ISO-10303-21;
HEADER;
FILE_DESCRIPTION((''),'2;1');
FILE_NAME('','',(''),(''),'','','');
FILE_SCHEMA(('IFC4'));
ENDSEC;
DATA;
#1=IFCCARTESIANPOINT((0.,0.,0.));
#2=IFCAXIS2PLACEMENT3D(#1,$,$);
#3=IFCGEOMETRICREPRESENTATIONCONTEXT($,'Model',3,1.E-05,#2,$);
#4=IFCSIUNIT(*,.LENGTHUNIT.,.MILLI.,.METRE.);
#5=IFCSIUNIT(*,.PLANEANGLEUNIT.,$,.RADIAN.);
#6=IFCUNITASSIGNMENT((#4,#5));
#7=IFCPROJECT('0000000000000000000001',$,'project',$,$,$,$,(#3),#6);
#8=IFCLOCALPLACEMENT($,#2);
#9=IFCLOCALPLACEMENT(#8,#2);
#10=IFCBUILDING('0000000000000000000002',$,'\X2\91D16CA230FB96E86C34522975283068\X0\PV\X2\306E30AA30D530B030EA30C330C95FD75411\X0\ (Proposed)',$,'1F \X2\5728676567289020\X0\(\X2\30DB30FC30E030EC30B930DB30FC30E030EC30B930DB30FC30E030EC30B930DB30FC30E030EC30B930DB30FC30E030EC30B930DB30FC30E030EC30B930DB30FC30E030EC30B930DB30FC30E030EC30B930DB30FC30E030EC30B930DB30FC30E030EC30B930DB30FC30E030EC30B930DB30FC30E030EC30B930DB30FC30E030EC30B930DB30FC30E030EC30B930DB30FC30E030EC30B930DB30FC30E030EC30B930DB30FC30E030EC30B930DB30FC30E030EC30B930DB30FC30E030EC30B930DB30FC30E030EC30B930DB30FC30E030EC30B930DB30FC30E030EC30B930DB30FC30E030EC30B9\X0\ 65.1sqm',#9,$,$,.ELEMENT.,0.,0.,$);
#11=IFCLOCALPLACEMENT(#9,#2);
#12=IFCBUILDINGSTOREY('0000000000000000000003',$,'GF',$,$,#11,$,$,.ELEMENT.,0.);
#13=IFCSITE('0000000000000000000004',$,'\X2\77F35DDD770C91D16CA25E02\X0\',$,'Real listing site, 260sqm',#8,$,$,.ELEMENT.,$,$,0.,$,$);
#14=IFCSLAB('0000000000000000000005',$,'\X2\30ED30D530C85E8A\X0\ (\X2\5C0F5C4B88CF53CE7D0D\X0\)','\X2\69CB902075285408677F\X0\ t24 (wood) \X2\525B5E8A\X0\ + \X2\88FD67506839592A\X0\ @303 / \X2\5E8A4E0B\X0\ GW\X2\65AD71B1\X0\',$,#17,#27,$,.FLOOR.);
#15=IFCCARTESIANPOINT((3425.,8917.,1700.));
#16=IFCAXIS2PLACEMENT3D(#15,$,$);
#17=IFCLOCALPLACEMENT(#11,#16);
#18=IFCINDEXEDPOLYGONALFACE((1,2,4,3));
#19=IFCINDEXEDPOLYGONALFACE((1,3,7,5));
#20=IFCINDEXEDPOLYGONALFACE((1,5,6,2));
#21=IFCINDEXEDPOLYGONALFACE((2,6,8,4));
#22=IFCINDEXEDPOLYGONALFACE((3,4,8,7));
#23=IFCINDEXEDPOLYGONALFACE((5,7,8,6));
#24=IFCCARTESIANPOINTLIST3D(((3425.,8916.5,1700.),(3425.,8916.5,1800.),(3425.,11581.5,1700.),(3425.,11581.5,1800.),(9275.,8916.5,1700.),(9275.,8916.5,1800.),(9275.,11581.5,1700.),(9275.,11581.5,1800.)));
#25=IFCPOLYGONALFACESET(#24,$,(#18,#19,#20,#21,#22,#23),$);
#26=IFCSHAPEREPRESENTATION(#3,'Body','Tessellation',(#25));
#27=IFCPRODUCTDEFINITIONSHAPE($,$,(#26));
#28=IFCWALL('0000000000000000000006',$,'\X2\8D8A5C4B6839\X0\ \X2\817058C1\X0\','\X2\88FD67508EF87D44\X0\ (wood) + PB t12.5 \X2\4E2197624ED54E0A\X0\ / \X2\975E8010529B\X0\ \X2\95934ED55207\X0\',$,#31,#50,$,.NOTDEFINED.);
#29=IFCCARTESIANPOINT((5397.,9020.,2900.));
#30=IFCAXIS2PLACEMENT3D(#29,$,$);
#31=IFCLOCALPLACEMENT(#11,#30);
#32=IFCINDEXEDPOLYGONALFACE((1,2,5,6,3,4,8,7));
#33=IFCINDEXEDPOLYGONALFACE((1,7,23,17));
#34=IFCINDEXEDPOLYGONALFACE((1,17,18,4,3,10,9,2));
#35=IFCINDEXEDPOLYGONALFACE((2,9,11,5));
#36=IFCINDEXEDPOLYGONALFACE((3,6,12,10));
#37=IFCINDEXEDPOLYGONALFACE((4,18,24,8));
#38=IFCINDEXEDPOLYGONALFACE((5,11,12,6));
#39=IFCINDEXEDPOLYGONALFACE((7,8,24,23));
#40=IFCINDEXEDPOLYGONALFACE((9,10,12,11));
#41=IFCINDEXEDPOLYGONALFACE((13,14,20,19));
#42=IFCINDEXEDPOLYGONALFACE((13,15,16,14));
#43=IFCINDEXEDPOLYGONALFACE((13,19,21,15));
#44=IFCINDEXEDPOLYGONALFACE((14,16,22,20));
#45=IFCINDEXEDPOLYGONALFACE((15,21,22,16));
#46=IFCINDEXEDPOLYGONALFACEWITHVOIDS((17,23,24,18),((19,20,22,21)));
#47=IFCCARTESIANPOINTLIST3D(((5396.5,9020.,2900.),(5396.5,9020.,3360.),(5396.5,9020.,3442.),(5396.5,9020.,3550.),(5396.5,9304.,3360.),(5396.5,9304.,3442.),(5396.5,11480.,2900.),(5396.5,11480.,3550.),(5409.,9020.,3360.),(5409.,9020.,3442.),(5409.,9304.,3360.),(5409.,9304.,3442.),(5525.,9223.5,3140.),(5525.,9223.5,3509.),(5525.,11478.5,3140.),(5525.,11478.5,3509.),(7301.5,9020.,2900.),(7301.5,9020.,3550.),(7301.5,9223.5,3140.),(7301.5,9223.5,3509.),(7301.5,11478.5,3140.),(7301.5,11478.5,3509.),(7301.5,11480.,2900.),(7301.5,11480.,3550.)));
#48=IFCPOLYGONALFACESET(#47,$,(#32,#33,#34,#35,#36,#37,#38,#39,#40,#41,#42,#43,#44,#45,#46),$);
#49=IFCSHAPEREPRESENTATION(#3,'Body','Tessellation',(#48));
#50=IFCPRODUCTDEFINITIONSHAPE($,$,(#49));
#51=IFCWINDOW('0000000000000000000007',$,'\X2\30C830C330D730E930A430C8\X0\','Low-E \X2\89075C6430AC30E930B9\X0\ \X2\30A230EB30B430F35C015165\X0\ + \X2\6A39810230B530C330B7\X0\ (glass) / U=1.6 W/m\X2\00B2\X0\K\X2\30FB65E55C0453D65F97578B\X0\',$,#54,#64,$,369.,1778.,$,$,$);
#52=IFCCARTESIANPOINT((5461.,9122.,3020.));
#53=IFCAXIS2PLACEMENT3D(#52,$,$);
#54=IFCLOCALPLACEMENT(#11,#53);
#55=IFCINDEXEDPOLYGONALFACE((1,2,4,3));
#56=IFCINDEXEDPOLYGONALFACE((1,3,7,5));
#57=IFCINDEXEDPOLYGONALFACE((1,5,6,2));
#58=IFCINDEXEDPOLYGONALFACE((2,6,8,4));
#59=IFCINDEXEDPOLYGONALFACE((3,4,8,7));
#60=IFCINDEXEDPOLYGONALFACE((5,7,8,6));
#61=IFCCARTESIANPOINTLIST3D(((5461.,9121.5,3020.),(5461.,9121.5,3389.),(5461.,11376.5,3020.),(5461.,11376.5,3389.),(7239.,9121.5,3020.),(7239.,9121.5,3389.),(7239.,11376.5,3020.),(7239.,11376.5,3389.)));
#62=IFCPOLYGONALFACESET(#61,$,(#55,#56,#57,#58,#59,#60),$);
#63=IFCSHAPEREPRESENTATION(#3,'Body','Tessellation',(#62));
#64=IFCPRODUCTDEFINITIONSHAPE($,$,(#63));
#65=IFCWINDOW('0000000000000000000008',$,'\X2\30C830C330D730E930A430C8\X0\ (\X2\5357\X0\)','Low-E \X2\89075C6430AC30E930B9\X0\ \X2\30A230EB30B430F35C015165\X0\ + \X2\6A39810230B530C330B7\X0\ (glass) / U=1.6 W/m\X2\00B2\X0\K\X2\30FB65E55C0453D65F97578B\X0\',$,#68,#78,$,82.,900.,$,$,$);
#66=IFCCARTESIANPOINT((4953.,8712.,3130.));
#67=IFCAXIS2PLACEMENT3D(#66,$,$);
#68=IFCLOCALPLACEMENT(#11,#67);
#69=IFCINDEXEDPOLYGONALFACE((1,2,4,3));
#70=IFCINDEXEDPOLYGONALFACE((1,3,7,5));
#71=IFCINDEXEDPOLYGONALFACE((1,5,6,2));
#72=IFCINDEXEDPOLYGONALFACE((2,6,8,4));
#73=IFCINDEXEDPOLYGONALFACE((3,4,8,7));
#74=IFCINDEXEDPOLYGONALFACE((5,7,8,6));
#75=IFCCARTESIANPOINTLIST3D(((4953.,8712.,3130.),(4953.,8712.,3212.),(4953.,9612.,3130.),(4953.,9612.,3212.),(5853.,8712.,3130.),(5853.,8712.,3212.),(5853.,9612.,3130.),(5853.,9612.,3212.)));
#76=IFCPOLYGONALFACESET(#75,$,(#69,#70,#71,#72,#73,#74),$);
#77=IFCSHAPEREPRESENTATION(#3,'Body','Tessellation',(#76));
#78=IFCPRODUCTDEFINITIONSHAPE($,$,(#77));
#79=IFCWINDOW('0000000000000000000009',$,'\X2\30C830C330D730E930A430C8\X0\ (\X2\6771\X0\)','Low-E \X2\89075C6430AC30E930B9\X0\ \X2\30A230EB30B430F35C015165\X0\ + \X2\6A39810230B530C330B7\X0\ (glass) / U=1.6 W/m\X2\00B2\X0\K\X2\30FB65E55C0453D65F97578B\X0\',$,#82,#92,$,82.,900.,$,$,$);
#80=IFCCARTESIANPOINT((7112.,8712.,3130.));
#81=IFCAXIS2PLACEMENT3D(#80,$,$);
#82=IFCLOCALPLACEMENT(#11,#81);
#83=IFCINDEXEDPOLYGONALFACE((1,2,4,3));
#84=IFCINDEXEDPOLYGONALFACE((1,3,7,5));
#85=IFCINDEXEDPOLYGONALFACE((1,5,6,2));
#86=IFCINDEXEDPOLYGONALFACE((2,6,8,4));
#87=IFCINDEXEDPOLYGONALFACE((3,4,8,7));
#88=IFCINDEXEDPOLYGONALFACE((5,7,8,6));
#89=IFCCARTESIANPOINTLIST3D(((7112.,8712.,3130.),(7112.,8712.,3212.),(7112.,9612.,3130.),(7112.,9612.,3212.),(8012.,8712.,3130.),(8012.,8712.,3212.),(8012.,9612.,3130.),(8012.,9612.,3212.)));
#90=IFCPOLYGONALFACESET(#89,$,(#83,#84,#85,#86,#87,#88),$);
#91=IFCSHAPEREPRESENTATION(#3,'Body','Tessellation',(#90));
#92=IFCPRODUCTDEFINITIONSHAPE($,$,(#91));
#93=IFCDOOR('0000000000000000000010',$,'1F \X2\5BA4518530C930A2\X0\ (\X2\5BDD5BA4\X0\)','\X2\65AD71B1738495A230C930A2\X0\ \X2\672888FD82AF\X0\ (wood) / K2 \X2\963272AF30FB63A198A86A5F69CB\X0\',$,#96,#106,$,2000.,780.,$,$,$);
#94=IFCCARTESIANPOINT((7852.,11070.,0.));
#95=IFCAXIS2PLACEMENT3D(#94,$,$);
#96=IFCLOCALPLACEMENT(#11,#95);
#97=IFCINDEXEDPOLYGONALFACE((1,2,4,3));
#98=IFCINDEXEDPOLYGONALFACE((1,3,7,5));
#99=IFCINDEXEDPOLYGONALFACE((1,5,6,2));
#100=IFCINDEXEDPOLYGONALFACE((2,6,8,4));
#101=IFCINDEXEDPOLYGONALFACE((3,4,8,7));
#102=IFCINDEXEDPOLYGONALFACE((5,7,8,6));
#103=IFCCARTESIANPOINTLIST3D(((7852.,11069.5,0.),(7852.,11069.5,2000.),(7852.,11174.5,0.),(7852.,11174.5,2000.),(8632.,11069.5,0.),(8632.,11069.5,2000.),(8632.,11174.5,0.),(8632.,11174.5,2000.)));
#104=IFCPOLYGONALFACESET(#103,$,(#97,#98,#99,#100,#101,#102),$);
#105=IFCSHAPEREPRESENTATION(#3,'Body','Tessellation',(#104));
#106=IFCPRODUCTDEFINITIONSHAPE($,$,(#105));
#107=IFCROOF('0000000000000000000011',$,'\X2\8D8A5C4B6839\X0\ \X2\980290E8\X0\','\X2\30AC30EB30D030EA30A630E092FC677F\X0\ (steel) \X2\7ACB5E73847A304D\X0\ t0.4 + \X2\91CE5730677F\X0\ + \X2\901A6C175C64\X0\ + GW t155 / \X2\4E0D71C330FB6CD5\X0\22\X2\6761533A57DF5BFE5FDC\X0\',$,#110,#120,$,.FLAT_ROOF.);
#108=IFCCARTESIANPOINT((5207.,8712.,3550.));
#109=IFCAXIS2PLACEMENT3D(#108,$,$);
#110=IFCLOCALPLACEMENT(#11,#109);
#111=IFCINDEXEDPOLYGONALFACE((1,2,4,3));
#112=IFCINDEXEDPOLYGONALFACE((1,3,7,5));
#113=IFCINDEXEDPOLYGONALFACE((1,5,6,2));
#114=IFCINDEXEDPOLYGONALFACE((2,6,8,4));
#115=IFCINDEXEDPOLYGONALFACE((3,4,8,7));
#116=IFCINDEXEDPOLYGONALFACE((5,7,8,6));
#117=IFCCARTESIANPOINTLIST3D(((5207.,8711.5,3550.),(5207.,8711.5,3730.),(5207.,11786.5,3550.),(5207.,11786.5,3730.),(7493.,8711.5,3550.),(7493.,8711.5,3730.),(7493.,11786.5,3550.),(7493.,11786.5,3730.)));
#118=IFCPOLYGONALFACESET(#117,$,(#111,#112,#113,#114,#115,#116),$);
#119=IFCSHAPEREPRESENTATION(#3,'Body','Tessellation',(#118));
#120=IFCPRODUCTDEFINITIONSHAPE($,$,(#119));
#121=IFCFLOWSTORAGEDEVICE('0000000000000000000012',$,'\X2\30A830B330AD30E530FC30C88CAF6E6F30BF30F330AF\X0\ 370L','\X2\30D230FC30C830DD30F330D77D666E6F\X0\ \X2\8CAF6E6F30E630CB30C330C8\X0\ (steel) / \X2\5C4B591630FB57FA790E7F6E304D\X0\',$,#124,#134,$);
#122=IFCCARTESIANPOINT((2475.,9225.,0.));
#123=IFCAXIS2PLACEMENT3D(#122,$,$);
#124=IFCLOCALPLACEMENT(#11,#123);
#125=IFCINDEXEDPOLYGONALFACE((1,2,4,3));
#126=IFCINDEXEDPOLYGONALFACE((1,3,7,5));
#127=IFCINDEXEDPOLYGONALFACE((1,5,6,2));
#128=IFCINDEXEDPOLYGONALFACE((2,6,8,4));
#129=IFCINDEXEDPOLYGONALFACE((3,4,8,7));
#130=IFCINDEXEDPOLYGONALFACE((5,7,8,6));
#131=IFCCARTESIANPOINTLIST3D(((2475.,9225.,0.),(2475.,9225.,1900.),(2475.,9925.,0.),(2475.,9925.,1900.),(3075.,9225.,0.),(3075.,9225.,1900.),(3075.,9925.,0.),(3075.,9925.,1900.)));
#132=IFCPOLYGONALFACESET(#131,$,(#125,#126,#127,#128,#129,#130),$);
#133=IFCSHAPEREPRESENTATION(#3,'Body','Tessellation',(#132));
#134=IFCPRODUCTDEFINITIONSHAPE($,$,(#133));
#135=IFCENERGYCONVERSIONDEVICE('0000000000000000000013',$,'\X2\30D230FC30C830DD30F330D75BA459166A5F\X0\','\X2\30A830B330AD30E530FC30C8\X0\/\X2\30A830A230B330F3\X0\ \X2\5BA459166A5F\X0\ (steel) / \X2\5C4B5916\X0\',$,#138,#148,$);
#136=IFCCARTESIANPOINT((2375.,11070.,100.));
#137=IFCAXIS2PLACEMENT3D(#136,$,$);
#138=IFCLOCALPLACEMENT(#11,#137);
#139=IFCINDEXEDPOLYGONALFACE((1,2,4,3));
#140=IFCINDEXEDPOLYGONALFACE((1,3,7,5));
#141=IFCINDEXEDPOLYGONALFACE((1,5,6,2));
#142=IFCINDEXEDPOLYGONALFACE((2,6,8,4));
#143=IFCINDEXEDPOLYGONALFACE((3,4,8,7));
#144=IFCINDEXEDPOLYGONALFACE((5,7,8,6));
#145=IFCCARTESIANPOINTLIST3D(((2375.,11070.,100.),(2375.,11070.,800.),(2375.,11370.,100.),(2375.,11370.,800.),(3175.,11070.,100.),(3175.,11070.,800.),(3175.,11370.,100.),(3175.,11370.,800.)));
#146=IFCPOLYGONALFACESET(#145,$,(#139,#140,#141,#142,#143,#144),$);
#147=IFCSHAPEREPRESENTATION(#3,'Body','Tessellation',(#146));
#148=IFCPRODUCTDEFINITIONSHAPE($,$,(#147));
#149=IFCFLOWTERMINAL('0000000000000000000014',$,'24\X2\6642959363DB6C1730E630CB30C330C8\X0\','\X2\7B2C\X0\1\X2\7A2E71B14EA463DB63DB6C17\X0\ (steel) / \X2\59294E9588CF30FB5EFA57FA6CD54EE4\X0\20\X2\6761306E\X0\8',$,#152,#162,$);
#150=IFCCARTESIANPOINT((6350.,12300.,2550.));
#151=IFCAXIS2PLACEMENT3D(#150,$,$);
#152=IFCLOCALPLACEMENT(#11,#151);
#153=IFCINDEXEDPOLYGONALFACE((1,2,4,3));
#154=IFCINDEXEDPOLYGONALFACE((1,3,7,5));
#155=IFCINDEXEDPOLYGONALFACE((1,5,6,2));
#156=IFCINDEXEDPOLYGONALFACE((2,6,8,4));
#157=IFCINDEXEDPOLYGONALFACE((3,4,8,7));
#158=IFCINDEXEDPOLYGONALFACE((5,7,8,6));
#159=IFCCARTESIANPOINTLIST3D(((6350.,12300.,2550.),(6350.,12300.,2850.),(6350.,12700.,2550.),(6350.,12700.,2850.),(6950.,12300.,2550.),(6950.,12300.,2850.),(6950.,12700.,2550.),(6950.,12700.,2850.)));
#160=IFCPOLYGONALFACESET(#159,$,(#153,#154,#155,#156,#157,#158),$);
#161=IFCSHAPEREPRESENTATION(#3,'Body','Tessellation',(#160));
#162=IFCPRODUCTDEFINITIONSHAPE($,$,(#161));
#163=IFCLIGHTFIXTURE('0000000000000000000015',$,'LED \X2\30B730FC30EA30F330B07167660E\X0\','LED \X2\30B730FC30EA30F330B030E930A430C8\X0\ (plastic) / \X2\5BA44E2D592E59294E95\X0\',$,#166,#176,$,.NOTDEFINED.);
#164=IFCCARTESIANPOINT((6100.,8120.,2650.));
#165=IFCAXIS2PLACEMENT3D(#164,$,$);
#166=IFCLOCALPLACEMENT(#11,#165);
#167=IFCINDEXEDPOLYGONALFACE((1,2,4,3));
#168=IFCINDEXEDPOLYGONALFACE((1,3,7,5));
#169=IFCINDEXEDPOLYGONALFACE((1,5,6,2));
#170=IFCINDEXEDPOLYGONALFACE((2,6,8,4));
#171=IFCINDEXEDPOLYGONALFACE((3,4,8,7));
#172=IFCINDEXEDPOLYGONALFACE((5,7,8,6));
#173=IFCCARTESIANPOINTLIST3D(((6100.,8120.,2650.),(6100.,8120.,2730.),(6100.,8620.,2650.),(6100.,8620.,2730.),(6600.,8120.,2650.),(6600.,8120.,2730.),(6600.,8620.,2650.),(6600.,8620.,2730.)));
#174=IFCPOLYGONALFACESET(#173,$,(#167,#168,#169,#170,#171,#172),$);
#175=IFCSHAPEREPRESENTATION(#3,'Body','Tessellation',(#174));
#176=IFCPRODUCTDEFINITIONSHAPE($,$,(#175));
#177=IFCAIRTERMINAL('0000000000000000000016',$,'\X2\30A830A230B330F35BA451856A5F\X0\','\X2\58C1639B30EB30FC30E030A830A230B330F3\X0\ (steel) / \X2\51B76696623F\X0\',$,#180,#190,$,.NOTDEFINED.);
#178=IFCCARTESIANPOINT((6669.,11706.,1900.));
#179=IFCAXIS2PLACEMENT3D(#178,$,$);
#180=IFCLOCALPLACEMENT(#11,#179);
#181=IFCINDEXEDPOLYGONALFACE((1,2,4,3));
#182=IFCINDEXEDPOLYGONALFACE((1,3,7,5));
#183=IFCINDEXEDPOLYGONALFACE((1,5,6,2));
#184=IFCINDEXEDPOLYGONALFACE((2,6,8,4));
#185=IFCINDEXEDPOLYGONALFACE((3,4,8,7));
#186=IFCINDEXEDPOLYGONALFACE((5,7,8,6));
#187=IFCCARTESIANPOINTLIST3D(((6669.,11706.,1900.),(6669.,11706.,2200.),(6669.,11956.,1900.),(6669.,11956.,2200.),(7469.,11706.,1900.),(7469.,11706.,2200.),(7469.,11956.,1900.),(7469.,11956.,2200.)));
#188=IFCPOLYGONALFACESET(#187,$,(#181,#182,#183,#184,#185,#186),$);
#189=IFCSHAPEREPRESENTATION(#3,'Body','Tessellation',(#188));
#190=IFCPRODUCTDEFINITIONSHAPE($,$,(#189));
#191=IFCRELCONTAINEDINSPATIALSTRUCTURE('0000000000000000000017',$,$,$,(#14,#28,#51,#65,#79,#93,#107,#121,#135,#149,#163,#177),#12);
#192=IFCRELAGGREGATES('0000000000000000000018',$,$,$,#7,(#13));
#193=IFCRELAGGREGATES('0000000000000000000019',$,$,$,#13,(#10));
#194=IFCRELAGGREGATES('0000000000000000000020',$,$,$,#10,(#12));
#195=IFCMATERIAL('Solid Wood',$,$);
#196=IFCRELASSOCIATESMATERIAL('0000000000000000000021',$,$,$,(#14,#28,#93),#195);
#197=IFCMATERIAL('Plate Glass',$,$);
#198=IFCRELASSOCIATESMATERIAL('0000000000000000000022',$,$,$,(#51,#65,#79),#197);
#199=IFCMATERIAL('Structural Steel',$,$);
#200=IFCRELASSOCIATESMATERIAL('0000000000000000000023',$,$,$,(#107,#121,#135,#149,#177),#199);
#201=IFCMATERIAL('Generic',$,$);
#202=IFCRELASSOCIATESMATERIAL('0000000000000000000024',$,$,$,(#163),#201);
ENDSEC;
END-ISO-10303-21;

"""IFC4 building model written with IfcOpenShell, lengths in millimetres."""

from ifc_helpers import new_model, si_unit, frame, frame_2d, origin, place, context, project, spatial, rectangle, extrude, material, element, fill, save


model = new_model("IFC4")

# Units and contexts
model_context = context("Model", 3, precision=1e-05, world=origin())
ifc_project = project(units=[si_unit("LENGTHUNIT", "METRE", prefix="MILLI"), si_unit("PLANEANGLEUNIT", "RADIAN")], contexts=[model_context])

# Site, building, storey
site_placement = place(None, origin())
site = spatial("IfcSite", under=ifc_project, at=site_placement, Name="石川県金沢市", ObjectType="Real listing site, 260sqm", CompositionType="ELEMENT", RefElevation=0.0)
building_placement = place(site_placement, origin())
building = spatial("IfcBuilding", under=site, at=building_placement, Name="金沢・雨水利用とPVのオフグリッド志向 (Proposed)", ObjectType="1F 在来木造(ホームレスホームレスホームレスホームレスホームレスホームレスホームレスホームレスホームレスホームレスホームレスホームレスホームレスホームレスホームレスホームレスホームレスホームレスホームレスホームレスホームレスホームレスホームレス 65.1sqm", CompositionType="ELEMENT", ElevationOfRefHeight=0.0, ElevationOfTerrain=0.0)
storey_placement = place(building_placement, origin())
storey = spatial("IfcBuildingStorey", under=building, at=storey_placement, Name="GF", CompositionType="ELEMENT", Elevation=0.0)

# Shared definitions
ifc_material_1 = material(Name="Solid Wood")

# Slab
slab_placement = place(storey_placement, frame((3425.0, 8917.0, 1700.0)))
element("IfcSlab", 1, at=slab_placement, inside=storey, material=ifc_material_1, Name="ロフト床 (小屋裏収納)", Description="構造用合板 t24 (wood) 剛床 + 製材根太 @303 / 床下 GW断熱", PredefinedType="FLOOR", context=model_context, shape_type="SweptSolid", body=[
    extrude(rectangle(XDim=5850.0, YDim=2665.0, at=frame_2d((2925.0, 1332.0))), frame((3425.0, 8917.0, 1700.0)), (0.0, 0.0, 1.0), 100.0),
])

# Wall, openings, windows
wall_1_placement = place(storey_placement, frame((5397.0, 9020.0, 2900.0)))
wall_1 = element("IfcWall", 2, at=wall_1_placement, inside=storey, material=ifc_material_1, Name="越屋根 腰壁", Description="製材軸組 (wood) + PB t12.5 両面仕上 / 非耐力 間仕切", PredefinedType="NOTDEFINED", context=model_context, shape_type="SweptSolid", body=[
    extrude(rectangle(XDim=1905.0, YDim=2460.0, at=frame_2d((952.0, 1230.0))), frame((5397.0, 9020.0, 2900.0)), (0.0, 0.0, 1.0), 650.0),
])
opening_1_placement = place(storey_placement, frame((5461.0, 9122.0, 3020.0)))
opening_1 = element("IfcOpeningElement", 3, at=opening_1_placement, cuts=wall_1, PredefinedType="NOTDEFINED", context=model_context, shape_type="SweptSolid", body=[
    extrude(rectangle(XDim=1778.0, YDim=2255.0, at=frame_2d((889.0, 1127.0))), frame((5461.0, 9122.0, 3020.0)), (0.0, 0.0, 1.0), 369.0),
])
opening_2_placement = place(storey_placement, frame((4953.0, 8712.0, 3130.0)))
opening_2 = element("IfcOpeningElement", 4, at=opening_2_placement, cuts=wall_1, PredefinedType="NOTDEFINED", context=model_context, shape_type="SweptSolid", body=[
    extrude(rectangle(XDim=900.0, YDim=900.0, at=frame_2d((450.0, 450.0))), frame((4953.0, 8712.0, 3130.0)), (0.0, 0.0, 1.0), 82.0),
])
opening_3_placement = place(storey_placement, frame((7112.0, 8712.0, 3130.0)))
opening_3 = element("IfcOpeningElement", 5, at=opening_3_placement, cuts=wall_1, PredefinedType="NOTDEFINED", context=model_context, shape_type="SweptSolid", body=[
    extrude(rectangle(XDim=900.0, YDim=900.0, at=frame_2d((450.0, 450.0))), frame((7112.0, 8712.0, 3130.0)), (0.0, 0.0, 1.0), 82.0),
])
ifc_material_2 = material(Name="Plate Glass")
window_1_placement = place(storey_placement, frame((5461.0, 9122.0, 3020.0)))
window_1 = element("IfcWindow", 6, at=window_1_placement, inside=storey, material=ifc_material_2, Name="トップライト", Description="Low-E 複層ガラス アルゴン封入 + 樹脂サッシ (glass) / U=1.6 W/m²K・日射取得型", OverallHeight=369.0, OverallWidth=1778.0, context=model_context, shape_type="SweptSolid", body=[
    extrude(rectangle(XDim=1778.0, YDim=2255.0, at=frame_2d((889.0, 1127.0))), frame((5461.0, 9122.0, 3020.0)), (0.0, 0.0, 1.0), 369.0),
])
fill(opening_1, window_1)
window_2_placement = place(storey_placement, frame((4953.0, 8712.0, 3130.0)))
window_2 = element("IfcWindow", 7, at=window_2_placement, inside=storey, material=ifc_material_2, Name="トップライト (南)", Description="Low-E 複層ガラス アルゴン封入 + 樹脂サッシ (glass) / U=1.6 W/m²K・日射取得型", OverallHeight=82.0, OverallWidth=900.0, context=model_context, shape_type="SweptSolid", body=[
    extrude(rectangle(XDim=900.0, YDim=900.0, at=frame_2d((450.0, 450.0))), frame((4953.0, 8712.0, 3130.0)), (0.0, 0.0, 1.0), 82.0),
])
fill(opening_2, window_2)
window_3_placement = place(storey_placement, frame((7112.0, 8712.0, 3130.0)))
window_3 = element("IfcWindow", 8, at=window_3_placement, inside=storey, material=ifc_material_2, Name="トップライト (東)", Description="Low-E 複層ガラス アルゴン封入 + 樹脂サッシ (glass) / U=1.6 W/m²K・日射取得型", OverallHeight=82.0, OverallWidth=900.0, context=model_context, shape_type="SweptSolid", body=[
    extrude(rectangle(XDim=900.0, YDim=900.0, at=frame_2d((450.0, 450.0))), frame((7112.0, 8712.0, 3130.0)), (0.0, 0.0, 1.0), 82.0),
])
fill(opening_3, window_3)

# Door
door_1_placement = place(storey_placement, frame((7852.0, 11070.0, 0.0)))
element("IfcDoor", 9, at=door_1_placement, inside=storey, material=ifc_material_1, Name="1F 室内ドア (寝室)", Description="断熱玄関ドア 木製芯 (wood) / K2 防犯・採風機構", OverallHeight=2000.0, OverallWidth=780.0, context=model_context, shape_type="SweptSolid", body=[
    extrude(rectangle(XDim=780.0, YDim=105.0, at=frame_2d((390.0, 52.0))), frame((7852.0, 11070.0, 0.0)), (0.0, 0.0, 1.0), 2000.0),
])

# Roof
ifc_material_3 = material(Name="Structural Steel")
roof_placement = place(storey_placement, frame((5207.0, 8712.0, 3550.0)))
element("IfcRoof", 10, at=roof_placement, inside=storey, material=ifc_material_3, Name="越屋根 頂部", Description="ガルバリウム鋼板 (steel) 立平葺き t0.4 + 野地板 + 通気層 + GW t155 / 不燃・法22条区域対応", PredefinedType="FLAT_ROOF", context=model_context, shape_type="SweptSolid", body=[
    extrude(rectangle(XDim=2286.0, YDim=3075.0, at=frame_2d((1143.0, 1537.0))), frame((5207.0, 8712.0, 3550.0)), (0.0, 0.0, 1.0), 180.0),
])

# Flow storage device
flow_storage_device_placement = place(storey_placement, frame((2475.0, 9225.0, 0.0)))
element("IfcFlowStorageDevice", 11, at=flow_storage_device_placement, inside=storey, material=ifc_material_3, Name="エコキュート貯湯タンク 370L", Description="ヒートポンプ給湯 貯湯ユニット (steel) / 屋外・基礎置き", context=model_context, shape_type="SweptSolid", body=[
    extrude(rectangle(XDim=600.0, YDim=700.0, at=frame_2d((300.0, 350.0))), frame((2475.0, 9225.0, 0.0)), (0.0, 0.0, 1.0), 1900.0),
])

# Energy conversion device
energy_conversion_device_placement = place(storey_placement, frame((2375.0, 11070.0, 100.0)))
element("IfcEnergyConversionDevice", 12, at=energy_conversion_device_placement, inside=storey, material=ifc_material_3, Name="ヒートポンプ室外機", Description="エコキュート/エアコン 室外機 (steel) / 屋外", context=model_context, shape_type="SweptSolid", body=[
    extrude(rectangle(XDim=800.0, YDim=300.0, at=frame_2d((400.0, 150.0))), frame((2375.0, 11070.0, 100.0)), (0.0, 0.0, 1.0), 700.0),
])

# Flow terminal
flow_terminal_placement = place(storey_placement, frame((6350.0, 12300.0, 2550.0)))
element("IfcFlowTerminal", 13, at=flow_terminal_placement, inside=storey, material=ifc_material_3, Name="24時間換気ユニット", Description="第1種熱交換換気 (steel) / 天井裏・建基法令20条の8", context=model_context, shape_type="SweptSolid", body=[
    extrude(rectangle(XDim=600.0, YDim=400.0, at=frame_2d((300.0, 200.0))), frame((6350.0, 12300.0, 2550.0)), (0.0, 0.0, 1.0), 300.0),
])

# Light fixture
ifc_material_4 = material(Name="Generic")
light_fixture_placement = place(storey_placement, frame((6100.0, 8120.0, 2650.0)))
element("IfcLightFixture", 14, at=light_fixture_placement, inside=storey, material=ifc_material_4, Name="LED シーリング照明", Description="LED シーリングライト (plastic) / 室中央天井", PredefinedType="NOTDEFINED", context=model_context, shape_type="SweptSolid", body=[
    extrude(rectangle(XDim=500.0, YDim=500.0, at=frame_2d((250.0, 250.0))), frame((6100.0, 8120.0, 2650.0)), (0.0, 0.0, 1.0), 80.0),
])

# Air terminal
air_terminal_placement = place(storey_placement, frame((6669.0, 11706.0, 1900.0)))
element("IfcAirTerminal", 15, at=air_terminal_placement, inside=storey, material=ifc_material_3, Name="エアコン室内機", Description="壁掛ルームエアコン (steel) / 冷暖房", PredefinedType="NOTDEFINED", context=model_context, shape_type="SweptSolid", body=[
    extrude(rectangle(XDim=800.0, YDim=250.0, at=frame_2d((400.0, 125.0))), frame((6669.0, 11706.0, 1900.0)), (0.0, 0.0, 1.0), 300.0),
])

save(model, "model.ifc")
